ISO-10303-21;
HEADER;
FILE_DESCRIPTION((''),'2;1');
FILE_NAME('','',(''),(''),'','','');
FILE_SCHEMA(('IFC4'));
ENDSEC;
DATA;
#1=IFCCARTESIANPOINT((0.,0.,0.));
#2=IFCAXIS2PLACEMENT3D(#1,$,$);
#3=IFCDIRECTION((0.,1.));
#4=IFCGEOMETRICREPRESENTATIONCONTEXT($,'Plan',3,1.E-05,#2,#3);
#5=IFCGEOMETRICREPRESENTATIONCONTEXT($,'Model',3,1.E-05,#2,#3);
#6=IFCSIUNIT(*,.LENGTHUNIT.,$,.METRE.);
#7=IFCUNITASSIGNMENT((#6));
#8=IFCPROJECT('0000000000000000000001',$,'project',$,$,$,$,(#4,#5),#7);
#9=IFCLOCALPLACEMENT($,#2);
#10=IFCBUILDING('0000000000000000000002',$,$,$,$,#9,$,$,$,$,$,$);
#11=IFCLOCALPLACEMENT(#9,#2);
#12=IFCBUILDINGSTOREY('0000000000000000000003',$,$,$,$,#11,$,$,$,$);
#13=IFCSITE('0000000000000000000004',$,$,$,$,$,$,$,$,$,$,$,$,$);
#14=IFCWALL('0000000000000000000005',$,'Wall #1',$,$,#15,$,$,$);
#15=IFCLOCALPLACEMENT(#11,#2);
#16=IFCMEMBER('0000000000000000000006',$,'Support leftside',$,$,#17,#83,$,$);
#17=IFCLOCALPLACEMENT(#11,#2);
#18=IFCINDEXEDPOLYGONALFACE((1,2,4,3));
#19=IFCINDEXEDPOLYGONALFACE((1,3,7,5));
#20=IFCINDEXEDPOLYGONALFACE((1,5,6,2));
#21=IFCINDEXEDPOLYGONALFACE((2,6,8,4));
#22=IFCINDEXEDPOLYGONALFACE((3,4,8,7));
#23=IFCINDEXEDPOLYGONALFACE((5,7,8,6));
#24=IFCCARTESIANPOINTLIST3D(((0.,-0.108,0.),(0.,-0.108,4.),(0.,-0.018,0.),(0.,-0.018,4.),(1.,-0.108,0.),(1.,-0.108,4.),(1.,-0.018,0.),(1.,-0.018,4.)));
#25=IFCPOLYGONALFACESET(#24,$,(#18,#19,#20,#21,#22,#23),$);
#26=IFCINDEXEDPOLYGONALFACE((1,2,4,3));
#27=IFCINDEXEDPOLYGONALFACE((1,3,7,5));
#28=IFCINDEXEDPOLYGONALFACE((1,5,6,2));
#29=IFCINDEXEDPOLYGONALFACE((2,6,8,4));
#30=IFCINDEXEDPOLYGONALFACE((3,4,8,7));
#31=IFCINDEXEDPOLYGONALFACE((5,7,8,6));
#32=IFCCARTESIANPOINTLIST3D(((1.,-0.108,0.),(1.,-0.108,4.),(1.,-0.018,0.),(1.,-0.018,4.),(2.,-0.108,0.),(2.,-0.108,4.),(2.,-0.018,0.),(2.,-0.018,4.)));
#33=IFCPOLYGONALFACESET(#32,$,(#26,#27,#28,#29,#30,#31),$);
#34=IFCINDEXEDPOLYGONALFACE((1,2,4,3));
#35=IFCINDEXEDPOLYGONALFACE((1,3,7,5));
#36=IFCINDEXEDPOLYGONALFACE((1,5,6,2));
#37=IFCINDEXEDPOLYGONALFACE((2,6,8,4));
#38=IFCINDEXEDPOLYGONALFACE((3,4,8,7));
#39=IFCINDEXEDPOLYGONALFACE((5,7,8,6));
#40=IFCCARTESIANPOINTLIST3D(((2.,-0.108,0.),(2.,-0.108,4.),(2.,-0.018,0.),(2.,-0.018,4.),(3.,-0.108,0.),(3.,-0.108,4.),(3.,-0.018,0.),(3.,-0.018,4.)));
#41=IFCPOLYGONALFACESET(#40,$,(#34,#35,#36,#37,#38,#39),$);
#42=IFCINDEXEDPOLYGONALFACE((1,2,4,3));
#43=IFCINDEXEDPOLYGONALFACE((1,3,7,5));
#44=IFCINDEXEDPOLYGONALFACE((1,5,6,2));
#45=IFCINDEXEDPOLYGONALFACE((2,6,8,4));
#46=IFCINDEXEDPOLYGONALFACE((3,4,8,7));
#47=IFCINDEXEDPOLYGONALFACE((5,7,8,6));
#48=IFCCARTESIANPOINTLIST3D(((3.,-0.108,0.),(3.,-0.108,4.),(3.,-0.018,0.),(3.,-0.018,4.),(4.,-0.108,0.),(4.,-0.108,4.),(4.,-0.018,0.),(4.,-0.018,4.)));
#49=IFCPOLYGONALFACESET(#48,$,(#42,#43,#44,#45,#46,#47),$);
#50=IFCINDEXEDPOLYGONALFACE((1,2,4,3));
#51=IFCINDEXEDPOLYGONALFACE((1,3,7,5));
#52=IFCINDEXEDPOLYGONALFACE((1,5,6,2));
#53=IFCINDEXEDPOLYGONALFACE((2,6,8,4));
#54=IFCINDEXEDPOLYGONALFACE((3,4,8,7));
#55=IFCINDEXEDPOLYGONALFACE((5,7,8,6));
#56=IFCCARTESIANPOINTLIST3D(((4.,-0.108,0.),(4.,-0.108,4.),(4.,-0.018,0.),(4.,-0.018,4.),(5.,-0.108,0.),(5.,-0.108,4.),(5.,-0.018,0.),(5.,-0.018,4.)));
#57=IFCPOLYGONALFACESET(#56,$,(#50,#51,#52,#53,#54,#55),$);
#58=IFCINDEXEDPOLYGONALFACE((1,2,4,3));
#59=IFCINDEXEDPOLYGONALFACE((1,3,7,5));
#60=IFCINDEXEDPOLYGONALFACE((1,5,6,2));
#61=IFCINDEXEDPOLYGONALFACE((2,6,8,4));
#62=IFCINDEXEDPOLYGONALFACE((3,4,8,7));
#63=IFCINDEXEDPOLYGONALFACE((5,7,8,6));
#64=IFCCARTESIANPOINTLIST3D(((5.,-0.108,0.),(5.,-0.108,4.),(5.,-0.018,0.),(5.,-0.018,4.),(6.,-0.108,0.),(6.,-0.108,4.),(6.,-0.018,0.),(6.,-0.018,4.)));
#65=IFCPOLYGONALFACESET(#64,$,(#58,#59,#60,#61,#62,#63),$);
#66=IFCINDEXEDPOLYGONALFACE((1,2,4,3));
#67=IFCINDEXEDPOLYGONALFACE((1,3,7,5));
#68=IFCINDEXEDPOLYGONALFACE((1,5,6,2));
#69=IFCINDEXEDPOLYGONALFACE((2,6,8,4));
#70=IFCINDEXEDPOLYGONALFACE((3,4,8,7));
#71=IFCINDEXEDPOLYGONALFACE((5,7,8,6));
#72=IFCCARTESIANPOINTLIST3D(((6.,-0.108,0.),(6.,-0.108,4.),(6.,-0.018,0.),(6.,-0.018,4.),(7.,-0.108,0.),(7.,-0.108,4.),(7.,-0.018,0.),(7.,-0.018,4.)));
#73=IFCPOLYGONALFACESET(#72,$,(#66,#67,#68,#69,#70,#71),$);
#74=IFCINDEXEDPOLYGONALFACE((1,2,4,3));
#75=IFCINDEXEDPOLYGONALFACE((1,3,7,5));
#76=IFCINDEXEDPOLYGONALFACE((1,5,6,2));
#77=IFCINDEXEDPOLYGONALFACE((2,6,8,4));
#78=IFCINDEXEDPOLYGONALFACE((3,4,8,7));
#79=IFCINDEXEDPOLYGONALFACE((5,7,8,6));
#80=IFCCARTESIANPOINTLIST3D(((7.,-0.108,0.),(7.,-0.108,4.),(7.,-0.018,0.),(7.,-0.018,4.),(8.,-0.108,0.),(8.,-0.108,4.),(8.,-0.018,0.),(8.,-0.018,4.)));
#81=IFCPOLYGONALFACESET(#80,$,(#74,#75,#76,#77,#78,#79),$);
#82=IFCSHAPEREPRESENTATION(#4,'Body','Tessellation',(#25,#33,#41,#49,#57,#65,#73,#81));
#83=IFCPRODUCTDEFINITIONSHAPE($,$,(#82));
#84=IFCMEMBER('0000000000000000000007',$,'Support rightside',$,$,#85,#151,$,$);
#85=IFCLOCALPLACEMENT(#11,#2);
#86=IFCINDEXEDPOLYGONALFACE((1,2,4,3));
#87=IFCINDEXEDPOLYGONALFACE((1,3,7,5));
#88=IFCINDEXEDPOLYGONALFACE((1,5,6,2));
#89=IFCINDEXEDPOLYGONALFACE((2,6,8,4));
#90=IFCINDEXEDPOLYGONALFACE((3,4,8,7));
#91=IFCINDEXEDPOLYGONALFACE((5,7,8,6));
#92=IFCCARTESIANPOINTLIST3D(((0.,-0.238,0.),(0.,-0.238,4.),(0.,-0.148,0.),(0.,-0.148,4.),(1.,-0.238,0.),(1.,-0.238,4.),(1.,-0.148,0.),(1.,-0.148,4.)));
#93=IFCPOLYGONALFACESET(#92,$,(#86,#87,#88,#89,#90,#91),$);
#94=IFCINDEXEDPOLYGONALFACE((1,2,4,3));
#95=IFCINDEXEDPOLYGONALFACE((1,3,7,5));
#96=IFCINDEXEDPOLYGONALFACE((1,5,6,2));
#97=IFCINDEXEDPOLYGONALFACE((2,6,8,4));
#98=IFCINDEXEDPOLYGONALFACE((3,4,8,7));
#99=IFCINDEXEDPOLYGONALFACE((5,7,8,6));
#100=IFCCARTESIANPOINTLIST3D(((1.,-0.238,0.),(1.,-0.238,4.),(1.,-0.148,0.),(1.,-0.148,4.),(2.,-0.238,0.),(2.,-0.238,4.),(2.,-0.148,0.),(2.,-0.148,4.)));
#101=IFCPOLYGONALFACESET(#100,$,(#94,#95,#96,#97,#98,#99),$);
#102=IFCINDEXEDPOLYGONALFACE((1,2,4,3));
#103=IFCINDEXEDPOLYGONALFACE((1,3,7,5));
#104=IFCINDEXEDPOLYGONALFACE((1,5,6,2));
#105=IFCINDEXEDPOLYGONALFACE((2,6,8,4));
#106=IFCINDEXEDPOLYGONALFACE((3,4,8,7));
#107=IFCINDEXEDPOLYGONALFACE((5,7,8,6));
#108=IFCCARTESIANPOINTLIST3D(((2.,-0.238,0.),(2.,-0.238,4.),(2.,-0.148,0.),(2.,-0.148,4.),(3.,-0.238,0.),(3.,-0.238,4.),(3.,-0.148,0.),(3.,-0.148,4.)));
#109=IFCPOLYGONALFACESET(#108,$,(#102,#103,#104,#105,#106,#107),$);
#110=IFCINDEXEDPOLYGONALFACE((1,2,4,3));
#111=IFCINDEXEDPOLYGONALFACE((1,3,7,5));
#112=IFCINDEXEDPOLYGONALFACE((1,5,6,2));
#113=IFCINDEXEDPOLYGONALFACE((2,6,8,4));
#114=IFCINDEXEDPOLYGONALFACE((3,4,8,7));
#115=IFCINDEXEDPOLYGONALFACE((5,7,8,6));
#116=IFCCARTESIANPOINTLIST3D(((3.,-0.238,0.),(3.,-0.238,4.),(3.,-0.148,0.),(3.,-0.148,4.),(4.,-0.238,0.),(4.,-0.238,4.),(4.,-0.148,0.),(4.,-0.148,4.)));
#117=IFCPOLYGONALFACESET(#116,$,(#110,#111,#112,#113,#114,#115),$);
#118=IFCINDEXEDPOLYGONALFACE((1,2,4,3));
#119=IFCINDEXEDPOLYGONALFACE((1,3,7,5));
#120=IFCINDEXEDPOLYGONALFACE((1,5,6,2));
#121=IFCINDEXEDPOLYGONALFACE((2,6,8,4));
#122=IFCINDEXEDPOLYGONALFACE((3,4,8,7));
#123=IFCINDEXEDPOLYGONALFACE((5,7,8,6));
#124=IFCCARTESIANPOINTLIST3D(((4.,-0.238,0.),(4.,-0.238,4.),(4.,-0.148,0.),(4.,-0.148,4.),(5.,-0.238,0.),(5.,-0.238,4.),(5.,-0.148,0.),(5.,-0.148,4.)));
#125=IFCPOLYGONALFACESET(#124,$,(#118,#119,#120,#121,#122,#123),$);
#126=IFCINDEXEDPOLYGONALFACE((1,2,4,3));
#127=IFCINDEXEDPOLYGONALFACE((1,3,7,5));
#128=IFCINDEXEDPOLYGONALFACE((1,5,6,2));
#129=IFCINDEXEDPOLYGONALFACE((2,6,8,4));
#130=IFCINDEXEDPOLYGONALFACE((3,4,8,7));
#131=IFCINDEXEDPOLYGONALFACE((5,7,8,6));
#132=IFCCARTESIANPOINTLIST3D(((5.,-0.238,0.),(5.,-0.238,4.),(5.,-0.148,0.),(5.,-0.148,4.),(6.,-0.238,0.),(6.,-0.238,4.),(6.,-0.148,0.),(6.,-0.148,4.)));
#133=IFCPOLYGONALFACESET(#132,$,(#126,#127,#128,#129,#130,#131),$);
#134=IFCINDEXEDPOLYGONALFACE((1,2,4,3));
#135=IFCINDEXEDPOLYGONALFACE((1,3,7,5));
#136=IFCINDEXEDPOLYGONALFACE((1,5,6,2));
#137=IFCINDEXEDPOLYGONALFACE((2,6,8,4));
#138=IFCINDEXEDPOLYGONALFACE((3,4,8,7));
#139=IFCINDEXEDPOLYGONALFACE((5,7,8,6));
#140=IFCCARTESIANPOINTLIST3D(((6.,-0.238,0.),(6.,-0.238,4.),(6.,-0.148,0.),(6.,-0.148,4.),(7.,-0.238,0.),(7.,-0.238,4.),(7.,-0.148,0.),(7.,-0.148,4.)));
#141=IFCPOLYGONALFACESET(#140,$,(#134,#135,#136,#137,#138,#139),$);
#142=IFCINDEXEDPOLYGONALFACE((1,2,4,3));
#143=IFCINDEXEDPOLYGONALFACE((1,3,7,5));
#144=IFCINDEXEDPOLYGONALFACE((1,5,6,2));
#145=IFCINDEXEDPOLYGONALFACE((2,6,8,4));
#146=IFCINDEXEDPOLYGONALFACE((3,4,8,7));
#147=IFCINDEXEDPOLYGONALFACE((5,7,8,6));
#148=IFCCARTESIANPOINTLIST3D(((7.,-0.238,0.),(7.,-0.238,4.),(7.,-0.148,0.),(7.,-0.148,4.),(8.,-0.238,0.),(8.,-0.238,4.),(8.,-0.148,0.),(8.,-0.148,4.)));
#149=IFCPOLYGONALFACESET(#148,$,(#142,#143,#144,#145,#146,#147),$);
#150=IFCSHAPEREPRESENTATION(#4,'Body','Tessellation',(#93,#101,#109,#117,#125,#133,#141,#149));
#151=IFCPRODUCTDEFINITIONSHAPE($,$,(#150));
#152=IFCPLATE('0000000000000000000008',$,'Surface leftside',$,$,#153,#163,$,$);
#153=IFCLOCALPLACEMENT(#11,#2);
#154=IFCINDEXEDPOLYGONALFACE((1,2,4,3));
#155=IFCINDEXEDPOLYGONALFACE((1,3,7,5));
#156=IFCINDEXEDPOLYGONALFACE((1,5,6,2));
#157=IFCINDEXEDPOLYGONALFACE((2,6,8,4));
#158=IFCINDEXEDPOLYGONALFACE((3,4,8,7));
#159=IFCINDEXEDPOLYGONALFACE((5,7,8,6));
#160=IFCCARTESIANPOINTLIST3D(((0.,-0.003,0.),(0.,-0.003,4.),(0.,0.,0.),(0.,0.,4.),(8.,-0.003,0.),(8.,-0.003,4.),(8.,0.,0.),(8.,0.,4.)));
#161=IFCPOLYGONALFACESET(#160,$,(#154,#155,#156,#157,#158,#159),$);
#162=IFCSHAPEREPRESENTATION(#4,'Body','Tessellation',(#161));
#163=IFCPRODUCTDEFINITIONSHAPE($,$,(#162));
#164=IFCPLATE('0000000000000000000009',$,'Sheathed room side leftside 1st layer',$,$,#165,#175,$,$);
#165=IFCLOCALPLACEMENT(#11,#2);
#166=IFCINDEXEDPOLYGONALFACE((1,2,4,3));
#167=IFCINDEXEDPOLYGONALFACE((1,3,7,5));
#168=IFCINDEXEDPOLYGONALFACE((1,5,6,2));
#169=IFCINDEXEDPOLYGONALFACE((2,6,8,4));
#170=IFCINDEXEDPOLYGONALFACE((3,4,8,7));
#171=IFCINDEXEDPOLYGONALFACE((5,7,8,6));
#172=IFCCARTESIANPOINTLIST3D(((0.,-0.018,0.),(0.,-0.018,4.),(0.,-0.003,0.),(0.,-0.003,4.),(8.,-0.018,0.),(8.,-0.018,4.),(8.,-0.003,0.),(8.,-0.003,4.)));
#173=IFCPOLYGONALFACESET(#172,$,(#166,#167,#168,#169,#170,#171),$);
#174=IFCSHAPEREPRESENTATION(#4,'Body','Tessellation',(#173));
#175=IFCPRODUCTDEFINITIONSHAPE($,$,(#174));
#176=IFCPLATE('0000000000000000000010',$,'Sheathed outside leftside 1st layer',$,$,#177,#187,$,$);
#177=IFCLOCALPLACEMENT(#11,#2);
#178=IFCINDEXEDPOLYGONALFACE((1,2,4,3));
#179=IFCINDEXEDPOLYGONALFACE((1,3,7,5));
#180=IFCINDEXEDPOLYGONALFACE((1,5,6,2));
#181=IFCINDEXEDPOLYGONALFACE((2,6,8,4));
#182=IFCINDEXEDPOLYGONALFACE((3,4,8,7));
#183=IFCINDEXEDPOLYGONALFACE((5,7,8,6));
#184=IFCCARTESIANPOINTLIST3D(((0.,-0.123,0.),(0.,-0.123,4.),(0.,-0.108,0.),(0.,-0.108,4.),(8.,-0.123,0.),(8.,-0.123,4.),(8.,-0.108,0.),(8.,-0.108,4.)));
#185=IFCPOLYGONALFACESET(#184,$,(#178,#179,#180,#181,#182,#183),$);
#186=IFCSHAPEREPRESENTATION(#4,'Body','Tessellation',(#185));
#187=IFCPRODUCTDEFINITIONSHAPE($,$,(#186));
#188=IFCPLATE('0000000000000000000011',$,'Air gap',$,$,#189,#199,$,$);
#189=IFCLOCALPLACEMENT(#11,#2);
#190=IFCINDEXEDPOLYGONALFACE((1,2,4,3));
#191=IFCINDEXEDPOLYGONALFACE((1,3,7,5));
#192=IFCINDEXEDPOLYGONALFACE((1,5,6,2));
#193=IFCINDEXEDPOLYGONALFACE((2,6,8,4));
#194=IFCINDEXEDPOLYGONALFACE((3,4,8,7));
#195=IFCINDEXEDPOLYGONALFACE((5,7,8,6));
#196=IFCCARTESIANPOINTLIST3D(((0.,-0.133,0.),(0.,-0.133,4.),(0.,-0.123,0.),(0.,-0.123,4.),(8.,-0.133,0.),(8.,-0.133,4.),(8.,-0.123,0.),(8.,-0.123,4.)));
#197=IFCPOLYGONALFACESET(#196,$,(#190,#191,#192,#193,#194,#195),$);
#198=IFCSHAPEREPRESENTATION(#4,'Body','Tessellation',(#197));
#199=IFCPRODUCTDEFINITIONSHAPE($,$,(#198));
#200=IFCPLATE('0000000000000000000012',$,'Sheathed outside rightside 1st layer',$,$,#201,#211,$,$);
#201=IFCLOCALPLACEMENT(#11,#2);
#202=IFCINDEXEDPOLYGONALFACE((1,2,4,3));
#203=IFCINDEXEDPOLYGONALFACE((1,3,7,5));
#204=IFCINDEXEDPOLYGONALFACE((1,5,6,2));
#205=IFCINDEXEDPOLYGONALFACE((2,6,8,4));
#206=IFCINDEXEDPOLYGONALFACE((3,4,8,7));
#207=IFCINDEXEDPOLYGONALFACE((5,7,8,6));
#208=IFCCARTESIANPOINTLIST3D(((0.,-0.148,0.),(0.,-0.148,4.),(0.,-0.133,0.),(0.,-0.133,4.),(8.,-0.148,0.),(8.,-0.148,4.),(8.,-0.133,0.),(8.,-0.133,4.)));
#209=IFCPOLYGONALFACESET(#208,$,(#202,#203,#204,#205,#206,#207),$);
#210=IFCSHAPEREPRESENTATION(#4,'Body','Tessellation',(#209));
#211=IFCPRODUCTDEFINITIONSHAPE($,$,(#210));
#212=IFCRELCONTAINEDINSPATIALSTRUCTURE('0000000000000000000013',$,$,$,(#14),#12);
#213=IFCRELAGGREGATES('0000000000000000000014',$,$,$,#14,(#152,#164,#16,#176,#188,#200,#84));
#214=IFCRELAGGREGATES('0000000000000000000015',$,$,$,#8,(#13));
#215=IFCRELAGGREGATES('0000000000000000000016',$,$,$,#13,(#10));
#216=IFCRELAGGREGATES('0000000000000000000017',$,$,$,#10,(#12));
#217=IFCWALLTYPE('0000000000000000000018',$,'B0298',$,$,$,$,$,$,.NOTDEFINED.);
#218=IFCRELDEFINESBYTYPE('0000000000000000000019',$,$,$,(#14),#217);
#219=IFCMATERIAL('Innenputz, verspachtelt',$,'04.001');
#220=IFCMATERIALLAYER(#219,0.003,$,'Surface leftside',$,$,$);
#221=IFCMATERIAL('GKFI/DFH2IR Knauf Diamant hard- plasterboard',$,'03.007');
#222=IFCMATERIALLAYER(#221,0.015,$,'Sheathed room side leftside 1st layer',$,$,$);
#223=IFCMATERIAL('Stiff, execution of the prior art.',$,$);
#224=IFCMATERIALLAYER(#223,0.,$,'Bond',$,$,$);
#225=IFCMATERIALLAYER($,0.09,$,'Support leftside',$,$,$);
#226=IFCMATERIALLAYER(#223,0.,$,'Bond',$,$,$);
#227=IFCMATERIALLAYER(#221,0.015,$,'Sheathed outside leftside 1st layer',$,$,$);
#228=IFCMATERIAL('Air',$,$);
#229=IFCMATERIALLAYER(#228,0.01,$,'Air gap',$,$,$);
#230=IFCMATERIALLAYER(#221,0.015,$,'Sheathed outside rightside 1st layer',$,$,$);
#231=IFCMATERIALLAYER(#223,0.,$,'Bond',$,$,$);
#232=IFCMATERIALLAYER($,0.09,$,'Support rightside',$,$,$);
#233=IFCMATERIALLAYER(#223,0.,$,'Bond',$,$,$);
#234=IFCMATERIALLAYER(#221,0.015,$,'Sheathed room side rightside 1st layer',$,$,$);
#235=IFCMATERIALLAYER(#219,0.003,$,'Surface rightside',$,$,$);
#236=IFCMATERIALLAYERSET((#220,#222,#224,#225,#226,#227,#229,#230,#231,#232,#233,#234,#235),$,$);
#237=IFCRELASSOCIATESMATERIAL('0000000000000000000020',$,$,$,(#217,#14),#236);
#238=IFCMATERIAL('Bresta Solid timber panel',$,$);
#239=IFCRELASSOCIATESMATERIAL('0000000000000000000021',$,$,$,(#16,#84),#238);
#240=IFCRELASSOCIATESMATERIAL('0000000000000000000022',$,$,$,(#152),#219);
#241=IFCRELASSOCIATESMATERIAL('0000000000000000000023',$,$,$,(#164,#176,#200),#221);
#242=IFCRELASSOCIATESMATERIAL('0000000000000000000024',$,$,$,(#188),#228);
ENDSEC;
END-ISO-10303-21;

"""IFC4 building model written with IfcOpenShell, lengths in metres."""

from ifc_helpers import new_model, si_unit, direction, frame, frame_2d, origin, origin_with_axes, place, context, project, spatial, rectangle, extrude, material, layer, layer_set, type_object, element, aggregate, save


model = new_model("IFC4")

# Units and contexts
plan_context = context("Plan", 3, precision=1e-05, world=origin(), true_north=direction((0.0, 1.0)))
model_context = context("Model", 3, precision=1e-05, world=origin(), true_north=direction((0.0, 1.0)))
ifc_project = project(units=[si_unit("LENGTHUNIT", "METRE")], contexts=[plan_context, model_context])

# Site, building, storey
site = spatial("IfcSite", under=ifc_project)
building_placement = place(None, origin())
building = spatial("IfcBuilding", under=site, at=building_placement)
storey_placement = place(building_placement, origin())
storey = spatial("IfcBuildingStorey", under=building, at=storey_placement)

# Wall, members, plates
ifc_material_1 = material(Name="Innenputz, verspachtelt", Category="04.001")
ifc_layer_1 = layer(ifc_material_1, 0.003, Name="Surface leftside")
ifc_material_2 = material(Name="GKFI/DFH2IR Knauf Diamant hard- plasterboard", Category="03.007")
ifc_layer_2 = layer(ifc_material_2, 0.015, Name="Sheathed room side leftside 1st layer")
ifc_material_3 = material(Name="Stiff, execution of the prior art.")
ifc_layer_3 = layer(ifc_material_3, 0.0, Name="Bond")
ifc_layer_4 = layer(None, 0.09, Name="Support leftside")
ifc_layer_5 = layer(ifc_material_3, 0.0, Name="Bond")
ifc_layer_6 = layer(ifc_material_2, 0.015, Name="Sheathed outside leftside 1st layer")
ifc_material_4 = material(Name="Air")
ifc_layer_7 = layer(ifc_material_4, 0.01, Name="Air gap")
ifc_layer_8 = layer(ifc_material_2, 0.015, Name="Sheathed outside rightside 1st layer")
ifc_layer_9 = layer(ifc_material_3, 0.0, Name="Bond")
ifc_layer_10 = layer(None, 0.09, Name="Support rightside")
ifc_layer_11 = layer(ifc_material_3, 0.0, Name="Bond")
ifc_layer_12 = layer(ifc_material_2, 0.015, Name="Sheathed room side rightside 1st layer")
ifc_layer_13 = layer(ifc_material_1, 0.003, Name="Surface rightside")
ifc_layer_set = layer_set([ifc_layer_1, ifc_layer_2, ifc_layer_3, ifc_layer_4, ifc_layer_5, ifc_layer_6, ifc_layer_7, ifc_layer_8, ifc_layer_9, ifc_layer_10, ifc_layer_11, ifc_layer_12, ifc_layer_13])
wall_type = type_object("IfcWallType", Name="B0298", PredefinedType="NOTDEFINED", material=ifc_layer_set)
wall_placement = place(None, frame((0.0, 0.0, 0.0), z_axis=(0.0, -1.0, 0.0), x_axis=(1.0, 0.0, 0.0)))
wall = element("IfcWall", 1, at=wall_placement, inside=storey, type_object=wall_type, material=ifc_layer_set, Name="Wall #1")
ifc_material_5 = material(Name="Bresta Solid timber panel")
member_1_placement = place(wall_placement, origin())
member_1 = element("IfcMember", 2, at=member_1_placement, material=ifc_material_5, Name="Support leftside", context=plan_context, shape_type="SweptSolid", body=[
    extrude(rectangle(XDim=1.0, YDim=0.09, at=frame_2d((0.5, 0.045), x_axis=(1.0, 0.0))), frame((0.0, 4.0, 0.018), z_axis=(0.0, -1.0, 0.0), x_axis=(1.0, 0.0, 0.0)), (0.0, 0.0, 1.0), 4.0),
    extrude(rectangle(XDim=1.0, YDim=0.09, at=frame_2d((0.5, 0.045), x_axis=(1.0, 0.0))), frame((1.0, 4.0, 0.018), z_axis=(0.0, -1.0, 0.0), x_axis=(1.0, 0.0, 0.0)), (0.0, 0.0, 1.0), 4.0),
    extrude(rectangle(XDim=1.0, YDim=0.09, at=frame_2d((0.5, 0.045), x_axis=(1.0, 0.0))), frame((2.0, 4.0, 0.018), z_axis=(0.0, -1.0, 0.0), x_axis=(1.0, 0.0, 0.0)), (0.0, 0.0, 1.0), 4.0),
    extrude(rectangle(XDim=1.0, YDim=0.09, at=frame_2d((0.5, 0.045), x_axis=(1.0, 0.0))), frame((3.0, 4.0, 0.018), z_axis=(0.0, -1.0, 0.0), x_axis=(1.0, 0.0, 0.0)), (0.0, 0.0, 1.0), 4.0),
    extrude(rectangle(XDim=1.0, YDim=0.09, at=frame_2d((0.5, 0.045), x_axis=(1.0, 0.0))), frame((4.0, 4.0, 0.018), z_axis=(0.0, -1.0, 0.0), x_axis=(1.0, 0.0, 0.0)), (0.0, 0.0, 1.0), 4.0),
    extrude(rectangle(XDim=1.0, YDim=0.09, at=frame_2d((0.5, 0.045), x_axis=(1.0, 0.0))), frame((5.0, 4.0, 0.018), z_axis=(0.0, -1.0, 0.0), x_axis=(1.0, 0.0, 0.0)), (0.0, 0.0, 1.0), 4.0),
    extrude(rectangle(XDim=1.0, YDim=0.09, at=frame_2d((0.5, 0.045), x_axis=(1.0, 0.0))), frame((6.0, 4.0, 0.018), z_axis=(0.0, -1.0, 0.0), x_axis=(1.0, 0.0, 0.0)), (0.0, 0.0, 1.0), 4.0),
    extrude(rectangle(XDim=1.0, YDim=0.09, at=frame_2d((0.5, 0.045), x_axis=(1.0, 0.0))), frame((7.0, 4.0, 0.018), z_axis=(0.0, -1.0, 0.0), x_axis=(1.0, 0.0, 0.0)), (0.0, 0.0, 1.0), 4.0),
])
member_2_placement = place(wall_placement, origin())
member_2 = element("IfcMember", 3, at=member_2_placement, material=ifc_material_5, Name="Support rightside", context=plan_context, shape_type="SweptSolid", body=[
    extrude(rectangle(XDim=1.0, YDim=0.09, at=frame_2d((0.5, 0.045), x_axis=(1.0, 0.0))), frame((0.0, 4.0, 0.148), z_axis=(0.0, -1.0, 0.0), x_axis=(1.0, 0.0, 0.0)), (0.0, 0.0, 1.0), 4.0),
    extrude(rectangle(XDim=1.0, YDim=0.09, at=frame_2d((0.5, 0.045), x_axis=(1.0, 0.0))), frame((1.0, 4.0, 0.148), z_axis=(0.0, -1.0, 0.0), x_axis=(1.0, 0.0, 0.0)), (0.0, 0.0, 1.0), 4.0),
    extrude(rectangle(XDim=1.0, YDim=0.09, at=frame_2d((0.5, 0.045), x_axis=(1.0, 0.0))), frame((2.0, 4.0, 0.148), z_axis=(0.0, -1.0, 0.0), x_axis=(1.0, 0.0, 0.0)), (0.0, 0.0, 1.0), 4.0),
    extrude(rectangle(XDim=1.0, YDim=0.09, at=frame_2d((0.5, 0.045), x_axis=(1.0, 0.0))), frame((3.0, 4.0, 0.148), z_axis=(0.0, -1.0, 0.0), x_axis=(1.0, 0.0, 0.0)), (0.0, 0.0, 1.0), 4.0),
    extrude(rectangle(XDim=1.0, YDim=0.09, at=frame_2d((0.5, 0.045), x_axis=(1.0, 0.0))), frame((4.0, 4.0, 0.148), z_axis=(0.0, -1.0, 0.0), x_axis=(1.0, 0.0, 0.0)), (0.0, 0.0, 1.0), 4.0),
    extrude(rectangle(XDim=1.0, YDim=0.09, at=frame_2d((0.5, 0.045), x_axis=(1.0, 0.0))), frame((5.0, 4.0, 0.148), z_axis=(0.0, -1.0, 0.0), x_axis=(1.0, 0.0, 0.0)), (0.0, 0.0, 1.0), 4.0),
    extrude(rectangle(XDim=1.0, YDim=0.09, at=frame_2d((0.5, 0.045), x_axis=(1.0, 0.0))), frame((6.0, 4.0, 0.148), z_axis=(0.0, -1.0, 0.0), x_axis=(1.0, 0.0, 0.0)), (0.0, 0.0, 1.0), 4.0),
    extrude(rectangle(XDim=1.0, YDim=0.09, at=frame_2d((0.5, 0.045), x_axis=(1.0, 0.0))), frame((7.0, 4.0, 0.148), z_axis=(0.0, -1.0, 0.0), x_axis=(1.0, 0.0, 0.0)), (0.0, 0.0, 1.0), 4.0),
])
plate_1_placement = place(wall_placement, origin())
plate_1 = element("IfcPlate", 4, at=plate_1_placement, material=ifc_material_1, Name="Surface leftside", context=plan_context, shape_type="SweptSolid", body=[
    extrude(rectangle(XDim=8.0, YDim=4.0, at=frame_2d((4.0, 2.0), x_axis=(1.0, 0.0))), origin_with_axes(), (0.0, 0.0, 1.0), 0.003),
])
plate_2_placement = place(wall_placement, origin())
plate_2 = element("IfcPlate", 5, at=plate_2_placement, material=ifc_material_2, Name="Sheathed room side leftside 1st layer", context=plan_context, shape_type="SweptSolid", body=[
    extrude(rectangle(XDim=8.0, YDim=4.0, at=frame_2d((4.0, 2.0), x_axis=(1.0, 0.0))), frame((0.0, 0.0, 0.003), z_axis=(0.0, 0.0, 1.0), x_axis=(1.0, 0.0, 0.0)), (0.0, 0.0, 1.0), 0.015),
])
plate_3_placement = place(wall_placement, origin())
plate_3 = element("IfcPlate", 6, at=plate_3_placement, material=ifc_material_2, Name="Sheathed outside leftside 1st layer", context=plan_context, shape_type="SweptSolid", body=[
    extrude(rectangle(XDim=8.0, YDim=4.0, at=frame_2d((4.0, 2.0), x_axis=(1.0, 0.0))), frame((0.0, 0.0, 0.108), z_axis=(0.0, 0.0, 1.0), x_axis=(1.0, 0.0, 0.0)), (0.0, 0.0, 1.0), 0.015),
])
plate_4_placement = place(wall_placement, origin())
plate_4 = element("IfcPlate", 7, at=plate_4_placement, material=ifc_material_4, Name="Air gap", context=plan_context, shape_type="SweptSolid", body=[
    extrude(rectangle(XDim=8.0, YDim=4.0, at=frame_2d((4.0, 2.0), x_axis=(1.0, 0.0))), frame((0.0, 0.0, 0.123), z_axis=(0.0, 0.0, 1.0), x_axis=(1.0, 0.0, 0.0)), (0.0, 0.0, 1.0), 0.01),
])
plate_5_placement = place(wall_placement, origin())
plate_5 = element("IfcPlate", 8, at=plate_5_placement, material=ifc_material_2, Name="Sheathed outside rightside 1st layer", context=plan_context, shape_type="SweptSolid", body=[
    extrude(rectangle(XDim=8.0, YDim=4.0, at=frame_2d((4.0, 2.0), x_axis=(1.0, 0.0))), frame((0.0, 0.0, 0.133), z_axis=(0.0, 0.0, 1.0), x_axis=(1.0, 0.0, 0.0)), (0.0, 0.0, 1.0), 0.015),
])
aggregate(wall, [plate_1, plate_2, member_1, plate_3, plate_4, plate_5, member_2])

save(model, "model.ifc")
